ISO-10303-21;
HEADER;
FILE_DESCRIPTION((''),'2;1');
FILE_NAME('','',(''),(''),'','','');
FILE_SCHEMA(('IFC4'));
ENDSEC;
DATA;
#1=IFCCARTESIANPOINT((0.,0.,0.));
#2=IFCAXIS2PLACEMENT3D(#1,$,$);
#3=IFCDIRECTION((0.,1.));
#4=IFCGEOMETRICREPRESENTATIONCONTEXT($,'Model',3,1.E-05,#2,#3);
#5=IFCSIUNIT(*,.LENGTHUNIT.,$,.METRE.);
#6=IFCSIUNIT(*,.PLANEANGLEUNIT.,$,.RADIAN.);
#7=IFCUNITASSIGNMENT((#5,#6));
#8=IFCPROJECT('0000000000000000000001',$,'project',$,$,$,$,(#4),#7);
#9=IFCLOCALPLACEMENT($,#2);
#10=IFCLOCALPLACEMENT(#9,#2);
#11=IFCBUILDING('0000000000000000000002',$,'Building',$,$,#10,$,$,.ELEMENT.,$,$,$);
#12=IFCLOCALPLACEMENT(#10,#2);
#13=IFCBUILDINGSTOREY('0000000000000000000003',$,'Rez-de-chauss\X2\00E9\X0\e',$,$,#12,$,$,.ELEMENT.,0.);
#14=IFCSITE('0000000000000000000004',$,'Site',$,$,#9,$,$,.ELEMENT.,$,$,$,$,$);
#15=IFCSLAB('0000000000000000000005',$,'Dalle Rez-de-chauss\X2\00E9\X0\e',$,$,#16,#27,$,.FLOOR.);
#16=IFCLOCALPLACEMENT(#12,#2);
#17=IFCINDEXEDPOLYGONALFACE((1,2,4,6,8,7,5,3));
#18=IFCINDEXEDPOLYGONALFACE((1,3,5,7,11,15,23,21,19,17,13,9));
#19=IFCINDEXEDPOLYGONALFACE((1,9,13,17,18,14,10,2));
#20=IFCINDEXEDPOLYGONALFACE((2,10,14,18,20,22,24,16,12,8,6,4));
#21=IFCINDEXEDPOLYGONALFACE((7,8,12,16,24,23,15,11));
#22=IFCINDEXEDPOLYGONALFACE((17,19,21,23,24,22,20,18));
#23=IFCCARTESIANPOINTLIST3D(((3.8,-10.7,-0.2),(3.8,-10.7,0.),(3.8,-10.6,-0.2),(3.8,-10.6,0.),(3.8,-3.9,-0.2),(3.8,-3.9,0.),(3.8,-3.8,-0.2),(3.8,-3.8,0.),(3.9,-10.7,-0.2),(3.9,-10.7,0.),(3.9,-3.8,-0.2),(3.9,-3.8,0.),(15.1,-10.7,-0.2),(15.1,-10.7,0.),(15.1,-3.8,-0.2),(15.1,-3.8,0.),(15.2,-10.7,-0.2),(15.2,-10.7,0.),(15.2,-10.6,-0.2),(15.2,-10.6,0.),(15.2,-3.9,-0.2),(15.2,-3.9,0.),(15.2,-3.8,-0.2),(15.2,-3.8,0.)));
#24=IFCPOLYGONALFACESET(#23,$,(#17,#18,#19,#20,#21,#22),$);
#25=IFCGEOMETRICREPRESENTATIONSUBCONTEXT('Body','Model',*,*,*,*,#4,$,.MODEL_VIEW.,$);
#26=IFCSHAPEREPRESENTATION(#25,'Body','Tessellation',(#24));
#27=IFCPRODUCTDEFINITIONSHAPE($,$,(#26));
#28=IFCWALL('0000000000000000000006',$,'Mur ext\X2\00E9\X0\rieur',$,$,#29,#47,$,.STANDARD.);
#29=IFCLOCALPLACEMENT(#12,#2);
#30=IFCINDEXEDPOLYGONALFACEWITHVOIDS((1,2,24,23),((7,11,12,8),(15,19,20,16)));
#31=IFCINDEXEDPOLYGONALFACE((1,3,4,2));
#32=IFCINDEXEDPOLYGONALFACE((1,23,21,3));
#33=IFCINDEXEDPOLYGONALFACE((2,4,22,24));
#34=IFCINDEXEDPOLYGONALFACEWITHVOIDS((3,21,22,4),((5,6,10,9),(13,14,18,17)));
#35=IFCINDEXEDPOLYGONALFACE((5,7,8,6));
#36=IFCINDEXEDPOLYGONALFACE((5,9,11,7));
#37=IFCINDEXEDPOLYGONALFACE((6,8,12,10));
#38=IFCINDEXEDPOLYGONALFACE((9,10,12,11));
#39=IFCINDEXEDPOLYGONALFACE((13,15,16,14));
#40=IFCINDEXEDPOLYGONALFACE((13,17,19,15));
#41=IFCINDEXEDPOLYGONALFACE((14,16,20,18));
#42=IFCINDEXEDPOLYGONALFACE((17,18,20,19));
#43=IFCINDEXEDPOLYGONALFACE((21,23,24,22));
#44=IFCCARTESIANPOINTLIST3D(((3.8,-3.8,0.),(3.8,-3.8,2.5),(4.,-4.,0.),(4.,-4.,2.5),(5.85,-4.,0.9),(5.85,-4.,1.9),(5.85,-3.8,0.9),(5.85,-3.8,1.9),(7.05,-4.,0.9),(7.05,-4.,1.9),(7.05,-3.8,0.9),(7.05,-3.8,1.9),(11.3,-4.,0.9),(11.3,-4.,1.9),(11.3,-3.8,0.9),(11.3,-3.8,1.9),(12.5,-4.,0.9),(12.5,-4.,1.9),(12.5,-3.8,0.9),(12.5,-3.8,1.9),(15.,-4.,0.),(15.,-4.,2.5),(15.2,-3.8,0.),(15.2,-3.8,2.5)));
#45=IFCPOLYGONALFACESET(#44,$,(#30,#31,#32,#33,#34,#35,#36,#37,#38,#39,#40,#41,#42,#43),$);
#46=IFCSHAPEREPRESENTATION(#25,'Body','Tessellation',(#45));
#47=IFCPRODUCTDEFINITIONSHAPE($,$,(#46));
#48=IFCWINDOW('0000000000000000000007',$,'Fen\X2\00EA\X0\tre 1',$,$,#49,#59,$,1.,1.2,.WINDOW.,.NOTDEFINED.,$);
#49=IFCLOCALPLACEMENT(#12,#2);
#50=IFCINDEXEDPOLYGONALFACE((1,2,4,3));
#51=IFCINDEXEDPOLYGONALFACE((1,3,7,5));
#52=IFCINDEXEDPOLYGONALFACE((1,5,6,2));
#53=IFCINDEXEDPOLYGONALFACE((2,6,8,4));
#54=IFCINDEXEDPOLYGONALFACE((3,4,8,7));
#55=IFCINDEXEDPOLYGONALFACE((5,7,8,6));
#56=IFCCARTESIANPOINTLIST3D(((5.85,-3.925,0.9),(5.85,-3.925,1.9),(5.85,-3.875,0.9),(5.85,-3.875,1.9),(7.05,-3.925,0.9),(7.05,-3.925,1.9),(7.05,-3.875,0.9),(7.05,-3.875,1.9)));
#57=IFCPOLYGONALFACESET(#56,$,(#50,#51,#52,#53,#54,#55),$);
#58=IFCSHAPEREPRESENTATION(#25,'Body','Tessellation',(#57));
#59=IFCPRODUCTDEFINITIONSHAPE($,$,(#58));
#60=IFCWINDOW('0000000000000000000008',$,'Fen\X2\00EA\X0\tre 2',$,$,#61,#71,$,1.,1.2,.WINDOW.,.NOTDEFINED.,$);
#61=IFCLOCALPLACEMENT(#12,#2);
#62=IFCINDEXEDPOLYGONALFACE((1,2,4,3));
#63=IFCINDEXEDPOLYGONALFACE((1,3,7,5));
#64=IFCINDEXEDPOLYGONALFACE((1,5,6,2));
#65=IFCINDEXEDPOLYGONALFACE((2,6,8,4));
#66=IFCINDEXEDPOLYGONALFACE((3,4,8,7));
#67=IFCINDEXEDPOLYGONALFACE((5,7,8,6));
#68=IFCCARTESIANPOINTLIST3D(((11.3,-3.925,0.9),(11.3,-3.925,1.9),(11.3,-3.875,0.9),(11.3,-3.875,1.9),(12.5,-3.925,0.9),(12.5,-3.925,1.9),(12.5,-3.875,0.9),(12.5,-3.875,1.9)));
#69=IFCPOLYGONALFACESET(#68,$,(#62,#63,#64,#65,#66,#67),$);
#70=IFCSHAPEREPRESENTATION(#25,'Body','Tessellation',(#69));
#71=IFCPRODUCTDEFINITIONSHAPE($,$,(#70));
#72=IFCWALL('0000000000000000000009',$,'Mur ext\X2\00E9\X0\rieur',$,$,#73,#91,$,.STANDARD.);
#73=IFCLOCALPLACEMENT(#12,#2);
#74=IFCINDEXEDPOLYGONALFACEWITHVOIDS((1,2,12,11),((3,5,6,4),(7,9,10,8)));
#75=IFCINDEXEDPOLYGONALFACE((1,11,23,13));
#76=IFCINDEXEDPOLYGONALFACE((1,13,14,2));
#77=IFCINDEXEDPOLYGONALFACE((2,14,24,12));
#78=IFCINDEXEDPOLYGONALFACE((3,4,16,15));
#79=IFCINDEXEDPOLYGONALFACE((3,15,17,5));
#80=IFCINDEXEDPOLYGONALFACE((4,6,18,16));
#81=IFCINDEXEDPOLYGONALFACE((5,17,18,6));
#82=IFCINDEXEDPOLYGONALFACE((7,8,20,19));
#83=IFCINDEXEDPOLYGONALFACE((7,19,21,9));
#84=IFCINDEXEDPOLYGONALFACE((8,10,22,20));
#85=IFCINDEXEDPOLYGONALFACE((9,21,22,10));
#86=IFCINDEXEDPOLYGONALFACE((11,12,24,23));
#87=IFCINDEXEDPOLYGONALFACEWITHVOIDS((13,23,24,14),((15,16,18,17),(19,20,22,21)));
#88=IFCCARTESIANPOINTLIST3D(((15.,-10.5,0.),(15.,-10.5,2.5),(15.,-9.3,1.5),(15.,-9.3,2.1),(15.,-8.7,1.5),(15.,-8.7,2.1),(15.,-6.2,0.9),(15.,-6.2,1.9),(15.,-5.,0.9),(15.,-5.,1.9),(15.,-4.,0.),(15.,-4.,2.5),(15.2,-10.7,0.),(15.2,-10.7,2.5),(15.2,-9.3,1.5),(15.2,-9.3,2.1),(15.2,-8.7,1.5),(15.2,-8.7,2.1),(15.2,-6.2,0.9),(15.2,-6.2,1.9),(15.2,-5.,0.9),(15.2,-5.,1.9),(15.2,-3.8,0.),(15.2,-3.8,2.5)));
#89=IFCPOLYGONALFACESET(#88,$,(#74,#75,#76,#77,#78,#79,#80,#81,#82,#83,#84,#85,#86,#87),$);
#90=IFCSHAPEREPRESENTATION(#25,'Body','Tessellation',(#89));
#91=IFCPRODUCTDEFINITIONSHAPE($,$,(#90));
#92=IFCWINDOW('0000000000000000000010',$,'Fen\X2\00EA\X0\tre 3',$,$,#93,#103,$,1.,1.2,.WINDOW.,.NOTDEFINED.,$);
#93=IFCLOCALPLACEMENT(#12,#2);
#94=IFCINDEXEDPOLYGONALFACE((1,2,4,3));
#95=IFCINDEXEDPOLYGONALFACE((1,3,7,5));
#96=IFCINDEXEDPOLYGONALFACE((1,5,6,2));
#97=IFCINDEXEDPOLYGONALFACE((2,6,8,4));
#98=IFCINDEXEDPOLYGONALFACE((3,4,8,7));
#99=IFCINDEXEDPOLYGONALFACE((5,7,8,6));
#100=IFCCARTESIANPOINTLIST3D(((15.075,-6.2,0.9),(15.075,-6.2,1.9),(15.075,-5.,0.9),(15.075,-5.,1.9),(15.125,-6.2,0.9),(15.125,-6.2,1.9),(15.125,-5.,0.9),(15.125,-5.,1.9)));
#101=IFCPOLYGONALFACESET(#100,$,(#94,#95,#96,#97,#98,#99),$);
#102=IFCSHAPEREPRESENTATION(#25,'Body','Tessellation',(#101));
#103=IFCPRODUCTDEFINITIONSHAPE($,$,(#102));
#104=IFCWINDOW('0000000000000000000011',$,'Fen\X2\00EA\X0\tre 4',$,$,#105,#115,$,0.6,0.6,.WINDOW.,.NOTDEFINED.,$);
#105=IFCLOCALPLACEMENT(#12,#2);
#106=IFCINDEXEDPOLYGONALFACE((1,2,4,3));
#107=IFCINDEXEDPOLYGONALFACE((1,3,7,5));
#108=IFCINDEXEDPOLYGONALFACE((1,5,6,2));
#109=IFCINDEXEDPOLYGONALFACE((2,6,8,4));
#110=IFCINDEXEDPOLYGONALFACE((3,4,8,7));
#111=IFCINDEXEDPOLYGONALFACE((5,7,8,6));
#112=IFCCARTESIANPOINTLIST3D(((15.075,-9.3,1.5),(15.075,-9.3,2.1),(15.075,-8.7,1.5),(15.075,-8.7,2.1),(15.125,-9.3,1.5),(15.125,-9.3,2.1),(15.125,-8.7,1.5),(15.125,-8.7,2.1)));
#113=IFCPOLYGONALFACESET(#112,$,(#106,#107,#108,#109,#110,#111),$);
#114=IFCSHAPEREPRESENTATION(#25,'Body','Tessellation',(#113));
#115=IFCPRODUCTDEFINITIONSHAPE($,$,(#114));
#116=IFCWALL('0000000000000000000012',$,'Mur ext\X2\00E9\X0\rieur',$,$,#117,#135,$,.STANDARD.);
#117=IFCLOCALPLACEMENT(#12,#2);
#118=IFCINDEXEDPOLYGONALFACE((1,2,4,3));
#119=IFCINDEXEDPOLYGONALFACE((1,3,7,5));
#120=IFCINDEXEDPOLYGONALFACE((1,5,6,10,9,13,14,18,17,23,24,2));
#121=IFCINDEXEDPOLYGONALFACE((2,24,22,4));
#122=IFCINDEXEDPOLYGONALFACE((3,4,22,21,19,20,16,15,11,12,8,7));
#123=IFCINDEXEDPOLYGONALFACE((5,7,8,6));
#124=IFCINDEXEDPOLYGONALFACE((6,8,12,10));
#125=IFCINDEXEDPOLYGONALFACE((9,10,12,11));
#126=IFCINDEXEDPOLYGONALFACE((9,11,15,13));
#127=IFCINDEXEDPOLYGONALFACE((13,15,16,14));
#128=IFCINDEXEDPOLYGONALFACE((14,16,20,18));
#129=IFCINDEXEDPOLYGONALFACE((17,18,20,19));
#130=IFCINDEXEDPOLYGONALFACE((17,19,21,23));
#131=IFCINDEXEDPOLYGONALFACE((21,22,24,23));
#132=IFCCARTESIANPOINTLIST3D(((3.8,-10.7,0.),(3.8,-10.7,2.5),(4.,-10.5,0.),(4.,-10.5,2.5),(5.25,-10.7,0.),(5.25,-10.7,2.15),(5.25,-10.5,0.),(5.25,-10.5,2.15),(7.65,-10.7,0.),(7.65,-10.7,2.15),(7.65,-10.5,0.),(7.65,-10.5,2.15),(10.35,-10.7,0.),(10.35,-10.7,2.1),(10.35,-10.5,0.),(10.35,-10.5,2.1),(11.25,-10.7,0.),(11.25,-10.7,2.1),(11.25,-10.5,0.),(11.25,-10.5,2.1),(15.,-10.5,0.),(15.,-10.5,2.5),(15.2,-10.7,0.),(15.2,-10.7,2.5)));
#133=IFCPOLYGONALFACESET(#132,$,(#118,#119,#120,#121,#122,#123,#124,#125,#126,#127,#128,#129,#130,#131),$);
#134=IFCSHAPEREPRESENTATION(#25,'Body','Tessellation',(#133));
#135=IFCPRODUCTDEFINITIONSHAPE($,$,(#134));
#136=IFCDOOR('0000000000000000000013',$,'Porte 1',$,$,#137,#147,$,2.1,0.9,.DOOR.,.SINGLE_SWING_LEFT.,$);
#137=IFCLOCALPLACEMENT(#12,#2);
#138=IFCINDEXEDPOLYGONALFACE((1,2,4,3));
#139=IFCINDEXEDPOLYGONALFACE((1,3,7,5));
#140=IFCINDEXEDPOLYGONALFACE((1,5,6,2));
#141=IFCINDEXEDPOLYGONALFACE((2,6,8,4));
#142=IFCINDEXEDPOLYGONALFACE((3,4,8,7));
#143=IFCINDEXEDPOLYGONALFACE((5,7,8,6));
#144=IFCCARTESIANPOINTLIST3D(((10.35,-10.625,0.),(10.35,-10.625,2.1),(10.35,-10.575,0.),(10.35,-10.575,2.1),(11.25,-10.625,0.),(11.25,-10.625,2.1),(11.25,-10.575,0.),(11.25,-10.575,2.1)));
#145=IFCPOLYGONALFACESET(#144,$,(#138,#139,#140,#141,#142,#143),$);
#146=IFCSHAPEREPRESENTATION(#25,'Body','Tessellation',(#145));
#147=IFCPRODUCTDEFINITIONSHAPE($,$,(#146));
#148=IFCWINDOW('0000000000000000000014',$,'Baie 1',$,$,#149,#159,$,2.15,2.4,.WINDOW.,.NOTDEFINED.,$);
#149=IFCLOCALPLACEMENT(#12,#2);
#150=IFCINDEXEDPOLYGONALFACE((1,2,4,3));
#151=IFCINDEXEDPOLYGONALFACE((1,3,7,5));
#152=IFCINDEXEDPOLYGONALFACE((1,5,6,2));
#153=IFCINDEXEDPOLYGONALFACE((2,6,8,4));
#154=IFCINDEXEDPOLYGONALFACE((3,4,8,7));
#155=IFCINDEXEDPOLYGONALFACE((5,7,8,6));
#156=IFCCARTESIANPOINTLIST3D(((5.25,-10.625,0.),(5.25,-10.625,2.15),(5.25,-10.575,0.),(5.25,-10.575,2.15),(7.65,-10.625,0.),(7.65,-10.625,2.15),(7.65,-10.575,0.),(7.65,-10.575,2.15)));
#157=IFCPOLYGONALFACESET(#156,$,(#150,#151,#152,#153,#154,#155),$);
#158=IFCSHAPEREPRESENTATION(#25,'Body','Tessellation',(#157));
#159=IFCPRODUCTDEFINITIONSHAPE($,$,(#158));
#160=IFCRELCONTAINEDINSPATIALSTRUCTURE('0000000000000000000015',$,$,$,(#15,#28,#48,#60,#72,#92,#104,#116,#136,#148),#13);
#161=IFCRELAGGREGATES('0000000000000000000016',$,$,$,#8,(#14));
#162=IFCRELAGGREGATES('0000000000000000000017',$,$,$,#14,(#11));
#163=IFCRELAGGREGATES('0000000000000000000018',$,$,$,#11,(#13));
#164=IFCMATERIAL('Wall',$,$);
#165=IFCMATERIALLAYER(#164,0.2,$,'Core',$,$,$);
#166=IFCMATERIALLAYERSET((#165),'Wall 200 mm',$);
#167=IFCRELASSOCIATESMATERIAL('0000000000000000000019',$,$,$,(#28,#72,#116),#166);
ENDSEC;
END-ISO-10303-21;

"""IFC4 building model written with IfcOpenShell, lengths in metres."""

from ifc_helpers import new_model, si_unit, direction, frame, origin, origin_2d, place, context, subcontext, project, spatial, polyline, rectangle, outline, extrude, material, layer, layer_set, layer_usage, element, fill, save


model = new_model("IFC4")

# Units and contexts
model_context = context("Model", 3, precision=1e-05, world=origin(), true_north=direction((0.0, 1.0)))
body_context = subcontext(model_context, "Body", "Model", "MODEL_VIEW")
ifc_project = project(units=[si_unit("LENGTHUNIT", "METRE"), si_unit("PLANEANGLEUNIT", "RADIAN")], contexts=[model_context])

# Site, building, storey
site_placement = place(None, origin())
site = spatial("IfcSite", under=ifc_project, at=site_placement, Name="Site", CompositionType="ELEMENT")
building_placement = place(site_placement, origin())
building = spatial("IfcBuilding", under=site, at=building_placement, Name="Building", CompositionType="ELEMENT")
storey_placement = place(building_placement, origin())
storey = spatial("IfcBuildingStorey", under=building, at=storey_placement, Name="Rez-de-chaussée", CompositionType="ELEMENT", Elevation=0.0)

# Slab
slab_placement = place(storey_placement, origin())
element("IfcSlab", 1, at=slab_placement, inside=storey, Name="Dalle Rez-de-chaussée", PredefinedType="FLOOR", context=body_context, shape_type="SweptSolid", body=[
    extrude(outline(polyline([(3.8, -3.8), (3.8, -3.9), (3.8, -10.6), (3.8, -10.7), (3.9, -10.7), (15.1, -10.7), (15.2, -10.7), (15.2, -10.6), (15.2, -3.9), (15.2, -3.8), (15.1, -3.8), (3.9, -3.8), (3.8, -3.8)])), frame((0.0, 0.0, -0.2)), (0.0, 0.0, 1.0), 0.2),
])

# Walls, openings, windows
ifc_material = material(Name="Wall")
ifc_layer = layer(ifc_material, 0.2, Name="Core")
ifc_layer_set = layer_set([ifc_layer], Name="Wall 200 mm")
ifc_layer_usage = layer_usage(ifc_layer_set, "AXIS2", "POSITIVE", -0.1)
wall_1_placement = place(storey_placement, frame((3.9, -3.9, 0.0)))
wall_1 = element("IfcWall", 2, at=wall_1_placement, inside=storey, material=ifc_layer_usage, Name="Mur extérieur", PredefinedType="STANDARD", context=body_context, shape_type="SweptSolid", body=[
    extrude(outline(polyline([(0.0, 0.0), (0.1, -0.1), (11.1, -0.1), (11.2, 0.0), (11.3, 0.1), (-0.1, 0.1), (0.0, 0.0)])), origin(), (0.0, 0.0, 1.0), 2.5),
])
opening_1_placement = place(wall_1_placement, frame((2.55, 0.0, 0.9)))
opening_1 = element("IfcOpeningElement", 3, at=opening_1_placement, cuts=wall_1, PredefinedType="OPENING", context=body_context, shape_type="SweptSolid", body=[
    extrude(rectangle(XDim=1.2, YDim=0.4, at=origin_2d()), origin(), (0.0, 0.0, 1.0), 1.0),
])
opening_2_placement = place(wall_1_placement, frame((8.0, 0.0, 0.9)))
opening_2 = element("IfcOpeningElement", 4, at=opening_2_placement, cuts=wall_1, PredefinedType="OPENING", context=body_context, shape_type="SweptSolid", body=[
    extrude(rectangle(XDim=1.2, YDim=0.4, at=origin_2d()), origin(), (0.0, 0.0, 1.0), 1.0),
])
window_1_placement = place(opening_1_placement, origin())
window_1 = element("IfcWindow", 5, at=window_1_placement, inside=storey, Name="Fenêtre 1", OverallHeight=1.0, OverallWidth=1.2, PartitioningType="NOTDEFINED", PredefinedType="WINDOW", context=body_context, shape_type="SweptSolid", body=[
    extrude(rectangle(XDim=1.2, YDim=0.05, at=origin_2d()), origin(), (0.0, 0.0, 1.0), 1.0),
])
fill(opening_1, window_1)
window_2_placement = place(opening_2_placement, origin())
window_2 = element("IfcWindow", 6, at=window_2_placement, inside=storey, Name="Fenêtre 2", OverallHeight=1.0, OverallWidth=1.2, PartitioningType="NOTDEFINED", PredefinedType="WINDOW", context=body_context, shape_type="SweptSolid", body=[
    extrude(rectangle(XDim=1.2, YDim=0.05, at=origin_2d()), origin(), (0.0, 0.0, 1.0), 1.0),
])
fill(opening_2, window_2)
wall_2_placement = place(storey_placement, frame((15.1, -3.9, 0.0), z_axis=(0.0, 0.0, 1.0), x_axis=(0.0, -1.0, 0.0)))
wall_2 = element("IfcWall", 7, at=wall_2_placement, inside=storey, material=ifc_layer_usage, Name="Mur extérieur", PredefinedType="STANDARD", context=body_context, shape_type="SweptSolid", body=[
    extrude(outline(polyline([(0.0, 0.0), (0.1, -0.1), (6.6, -0.1), (6.7, 0.0), (6.8, 0.1), (-0.1, 0.1), (0.0, 0.0)])), origin(), (0.0, 0.0, 1.0), 2.5),
])
opening_3_placement = place(wall_2_placement, frame((1.7, 0.0, 0.9)))
opening_3 = element("IfcOpeningElement", 8, at=opening_3_placement, cuts=wall_2, PredefinedType="OPENING", context=body_context, shape_type="SweptSolid", body=[
    extrude(rectangle(XDim=1.2, YDim=0.4, at=origin_2d()), origin(), (0.0, 0.0, 1.0), 1.0),
])
opening_4_placement = place(wall_2_placement, frame((5.1, 0.0, 1.5)))
opening_4 = element("IfcOpeningElement", 9, at=opening_4_placement, cuts=wall_2, PredefinedType="OPENING", context=body_context, shape_type="SweptSolid", body=[
    extrude(rectangle(XDim=0.6, YDim=0.4, at=origin_2d()), origin(), (0.0, 0.0, 1.0), 0.6),
])
window_3_placement = place(opening_3_placement, origin())
window_3 = element("IfcWindow", 10, at=window_3_placement, inside=storey, Name="Fenêtre 3", OverallHeight=1.0, OverallWidth=1.2, PartitioningType="NOTDEFINED", PredefinedType="WINDOW", context=body_context, shape_type="SweptSolid", body=[
    extrude(rectangle(XDim=1.2, YDim=0.05, at=origin_2d()), origin(), (0.0, 0.0, 1.0), 1.0),
])
fill(opening_3, window_3)
window_4_placement = place(opening_4_placement, origin())
window_4 = element("IfcWindow", 11, at=window_4_placement, inside=storey, Name="Fenêtre 4", OverallHeight=0.6, OverallWidth=0.6, PartitioningType="NOTDEFINED", PredefinedType="WINDOW", context=body_context, shape_type="SweptSolid", body=[
    extrude(rectangle(XDim=0.6, YDim=0.05, at=origin_2d()), origin(), (0.0, 0.0, 1.0), 0.6),
])
fill(opening_4, window_4)

# Wall, openings, door, window
wall_3_placement = place(storey_placement, frame((15.1, -10.6, 0.0), z_axis=(0.0, 0.0, 1.0), x_axis=(-1.0, 0.0, 0.0)))
wall_3 = element("IfcWall", 12, at=wall_3_placement, inside=storey, material=ifc_layer_usage, Name="Mur extérieur", PredefinedType="STANDARD", context=body_context, shape_type="SweptSolid", body=[
    extrude(outline(polyline([(0.0, 0.0), (0.1, -0.1), (11.1, -0.1), (11.2, 0.0), (11.3, 0.1), (-0.1, 0.1), (0.0, 0.0)])), origin(), (0.0, 0.0, 1.0), 2.5),
])
opening_5_placement = place(wall_3_placement, frame((4.3, 0.0, 0.0), z_axis=(0.0, 0.0, 1.0), x_axis=(1.0, 0.0, 0.0)))
opening_5 = element("IfcOpeningElement", 13, at=opening_5_placement, cuts=wall_3, PredefinedType="OPENING", context=body_context, shape_type="SweptSolid", body=[
    extrude(rectangle(XDim=0.9, YDim=0.4, at=origin_2d()), origin(), (0.0, 0.0, 1.0), 2.1),
])
opening_6_placement = place(wall_3_placement, frame((8.65, 0.0, 0.0), z_axis=(0.0, 0.0, 1.0), x_axis=(1.0, 0.0, 0.0)))
opening_6 = element("IfcOpeningElement", 14, at=opening_6_placement, cuts=wall_3, PredefinedType="OPENING", context=body_context, shape_type="SweptSolid", body=[
    extrude(rectangle(XDim=2.4, YDim=0.4, at=origin_2d()), origin(), (0.0, 0.0, 1.0), 2.15),
])
door_1_placement = place(opening_5_placement, origin())
door_1 = element("IfcDoor", 15, at=door_1_placement, inside=storey, Name="Porte 1", OperationType="SINGLE_SWING_LEFT", OverallHeight=2.1, OverallWidth=0.9, PredefinedType="DOOR", context=body_context, shape_type="SweptSolid", body=[
    extrude(rectangle(XDim=0.9, YDim=0.05, at=origin_2d()), origin(), (0.0, 0.0, 1.0), 2.1),
])
fill(opening_5, door_1)
window_5_placement = place(opening_6_placement, origin())
window_5 = element("IfcWindow", 16, at=window_5_placement, inside=storey, Name="Baie 1", OverallHeight=2.15, OverallWidth=2.4, PartitioningType="NOTDEFINED", PredefinedType="WINDOW", context=body_context, shape_type="SweptSolid", body=[
    extrude(rectangle(XDim=2.4, YDim=0.05, at=origin_2d()), origin(), (0.0, 0.0, 1.0), 2.15),
])
fill(opening_6, window_5)

save(model, "model.ifc")
